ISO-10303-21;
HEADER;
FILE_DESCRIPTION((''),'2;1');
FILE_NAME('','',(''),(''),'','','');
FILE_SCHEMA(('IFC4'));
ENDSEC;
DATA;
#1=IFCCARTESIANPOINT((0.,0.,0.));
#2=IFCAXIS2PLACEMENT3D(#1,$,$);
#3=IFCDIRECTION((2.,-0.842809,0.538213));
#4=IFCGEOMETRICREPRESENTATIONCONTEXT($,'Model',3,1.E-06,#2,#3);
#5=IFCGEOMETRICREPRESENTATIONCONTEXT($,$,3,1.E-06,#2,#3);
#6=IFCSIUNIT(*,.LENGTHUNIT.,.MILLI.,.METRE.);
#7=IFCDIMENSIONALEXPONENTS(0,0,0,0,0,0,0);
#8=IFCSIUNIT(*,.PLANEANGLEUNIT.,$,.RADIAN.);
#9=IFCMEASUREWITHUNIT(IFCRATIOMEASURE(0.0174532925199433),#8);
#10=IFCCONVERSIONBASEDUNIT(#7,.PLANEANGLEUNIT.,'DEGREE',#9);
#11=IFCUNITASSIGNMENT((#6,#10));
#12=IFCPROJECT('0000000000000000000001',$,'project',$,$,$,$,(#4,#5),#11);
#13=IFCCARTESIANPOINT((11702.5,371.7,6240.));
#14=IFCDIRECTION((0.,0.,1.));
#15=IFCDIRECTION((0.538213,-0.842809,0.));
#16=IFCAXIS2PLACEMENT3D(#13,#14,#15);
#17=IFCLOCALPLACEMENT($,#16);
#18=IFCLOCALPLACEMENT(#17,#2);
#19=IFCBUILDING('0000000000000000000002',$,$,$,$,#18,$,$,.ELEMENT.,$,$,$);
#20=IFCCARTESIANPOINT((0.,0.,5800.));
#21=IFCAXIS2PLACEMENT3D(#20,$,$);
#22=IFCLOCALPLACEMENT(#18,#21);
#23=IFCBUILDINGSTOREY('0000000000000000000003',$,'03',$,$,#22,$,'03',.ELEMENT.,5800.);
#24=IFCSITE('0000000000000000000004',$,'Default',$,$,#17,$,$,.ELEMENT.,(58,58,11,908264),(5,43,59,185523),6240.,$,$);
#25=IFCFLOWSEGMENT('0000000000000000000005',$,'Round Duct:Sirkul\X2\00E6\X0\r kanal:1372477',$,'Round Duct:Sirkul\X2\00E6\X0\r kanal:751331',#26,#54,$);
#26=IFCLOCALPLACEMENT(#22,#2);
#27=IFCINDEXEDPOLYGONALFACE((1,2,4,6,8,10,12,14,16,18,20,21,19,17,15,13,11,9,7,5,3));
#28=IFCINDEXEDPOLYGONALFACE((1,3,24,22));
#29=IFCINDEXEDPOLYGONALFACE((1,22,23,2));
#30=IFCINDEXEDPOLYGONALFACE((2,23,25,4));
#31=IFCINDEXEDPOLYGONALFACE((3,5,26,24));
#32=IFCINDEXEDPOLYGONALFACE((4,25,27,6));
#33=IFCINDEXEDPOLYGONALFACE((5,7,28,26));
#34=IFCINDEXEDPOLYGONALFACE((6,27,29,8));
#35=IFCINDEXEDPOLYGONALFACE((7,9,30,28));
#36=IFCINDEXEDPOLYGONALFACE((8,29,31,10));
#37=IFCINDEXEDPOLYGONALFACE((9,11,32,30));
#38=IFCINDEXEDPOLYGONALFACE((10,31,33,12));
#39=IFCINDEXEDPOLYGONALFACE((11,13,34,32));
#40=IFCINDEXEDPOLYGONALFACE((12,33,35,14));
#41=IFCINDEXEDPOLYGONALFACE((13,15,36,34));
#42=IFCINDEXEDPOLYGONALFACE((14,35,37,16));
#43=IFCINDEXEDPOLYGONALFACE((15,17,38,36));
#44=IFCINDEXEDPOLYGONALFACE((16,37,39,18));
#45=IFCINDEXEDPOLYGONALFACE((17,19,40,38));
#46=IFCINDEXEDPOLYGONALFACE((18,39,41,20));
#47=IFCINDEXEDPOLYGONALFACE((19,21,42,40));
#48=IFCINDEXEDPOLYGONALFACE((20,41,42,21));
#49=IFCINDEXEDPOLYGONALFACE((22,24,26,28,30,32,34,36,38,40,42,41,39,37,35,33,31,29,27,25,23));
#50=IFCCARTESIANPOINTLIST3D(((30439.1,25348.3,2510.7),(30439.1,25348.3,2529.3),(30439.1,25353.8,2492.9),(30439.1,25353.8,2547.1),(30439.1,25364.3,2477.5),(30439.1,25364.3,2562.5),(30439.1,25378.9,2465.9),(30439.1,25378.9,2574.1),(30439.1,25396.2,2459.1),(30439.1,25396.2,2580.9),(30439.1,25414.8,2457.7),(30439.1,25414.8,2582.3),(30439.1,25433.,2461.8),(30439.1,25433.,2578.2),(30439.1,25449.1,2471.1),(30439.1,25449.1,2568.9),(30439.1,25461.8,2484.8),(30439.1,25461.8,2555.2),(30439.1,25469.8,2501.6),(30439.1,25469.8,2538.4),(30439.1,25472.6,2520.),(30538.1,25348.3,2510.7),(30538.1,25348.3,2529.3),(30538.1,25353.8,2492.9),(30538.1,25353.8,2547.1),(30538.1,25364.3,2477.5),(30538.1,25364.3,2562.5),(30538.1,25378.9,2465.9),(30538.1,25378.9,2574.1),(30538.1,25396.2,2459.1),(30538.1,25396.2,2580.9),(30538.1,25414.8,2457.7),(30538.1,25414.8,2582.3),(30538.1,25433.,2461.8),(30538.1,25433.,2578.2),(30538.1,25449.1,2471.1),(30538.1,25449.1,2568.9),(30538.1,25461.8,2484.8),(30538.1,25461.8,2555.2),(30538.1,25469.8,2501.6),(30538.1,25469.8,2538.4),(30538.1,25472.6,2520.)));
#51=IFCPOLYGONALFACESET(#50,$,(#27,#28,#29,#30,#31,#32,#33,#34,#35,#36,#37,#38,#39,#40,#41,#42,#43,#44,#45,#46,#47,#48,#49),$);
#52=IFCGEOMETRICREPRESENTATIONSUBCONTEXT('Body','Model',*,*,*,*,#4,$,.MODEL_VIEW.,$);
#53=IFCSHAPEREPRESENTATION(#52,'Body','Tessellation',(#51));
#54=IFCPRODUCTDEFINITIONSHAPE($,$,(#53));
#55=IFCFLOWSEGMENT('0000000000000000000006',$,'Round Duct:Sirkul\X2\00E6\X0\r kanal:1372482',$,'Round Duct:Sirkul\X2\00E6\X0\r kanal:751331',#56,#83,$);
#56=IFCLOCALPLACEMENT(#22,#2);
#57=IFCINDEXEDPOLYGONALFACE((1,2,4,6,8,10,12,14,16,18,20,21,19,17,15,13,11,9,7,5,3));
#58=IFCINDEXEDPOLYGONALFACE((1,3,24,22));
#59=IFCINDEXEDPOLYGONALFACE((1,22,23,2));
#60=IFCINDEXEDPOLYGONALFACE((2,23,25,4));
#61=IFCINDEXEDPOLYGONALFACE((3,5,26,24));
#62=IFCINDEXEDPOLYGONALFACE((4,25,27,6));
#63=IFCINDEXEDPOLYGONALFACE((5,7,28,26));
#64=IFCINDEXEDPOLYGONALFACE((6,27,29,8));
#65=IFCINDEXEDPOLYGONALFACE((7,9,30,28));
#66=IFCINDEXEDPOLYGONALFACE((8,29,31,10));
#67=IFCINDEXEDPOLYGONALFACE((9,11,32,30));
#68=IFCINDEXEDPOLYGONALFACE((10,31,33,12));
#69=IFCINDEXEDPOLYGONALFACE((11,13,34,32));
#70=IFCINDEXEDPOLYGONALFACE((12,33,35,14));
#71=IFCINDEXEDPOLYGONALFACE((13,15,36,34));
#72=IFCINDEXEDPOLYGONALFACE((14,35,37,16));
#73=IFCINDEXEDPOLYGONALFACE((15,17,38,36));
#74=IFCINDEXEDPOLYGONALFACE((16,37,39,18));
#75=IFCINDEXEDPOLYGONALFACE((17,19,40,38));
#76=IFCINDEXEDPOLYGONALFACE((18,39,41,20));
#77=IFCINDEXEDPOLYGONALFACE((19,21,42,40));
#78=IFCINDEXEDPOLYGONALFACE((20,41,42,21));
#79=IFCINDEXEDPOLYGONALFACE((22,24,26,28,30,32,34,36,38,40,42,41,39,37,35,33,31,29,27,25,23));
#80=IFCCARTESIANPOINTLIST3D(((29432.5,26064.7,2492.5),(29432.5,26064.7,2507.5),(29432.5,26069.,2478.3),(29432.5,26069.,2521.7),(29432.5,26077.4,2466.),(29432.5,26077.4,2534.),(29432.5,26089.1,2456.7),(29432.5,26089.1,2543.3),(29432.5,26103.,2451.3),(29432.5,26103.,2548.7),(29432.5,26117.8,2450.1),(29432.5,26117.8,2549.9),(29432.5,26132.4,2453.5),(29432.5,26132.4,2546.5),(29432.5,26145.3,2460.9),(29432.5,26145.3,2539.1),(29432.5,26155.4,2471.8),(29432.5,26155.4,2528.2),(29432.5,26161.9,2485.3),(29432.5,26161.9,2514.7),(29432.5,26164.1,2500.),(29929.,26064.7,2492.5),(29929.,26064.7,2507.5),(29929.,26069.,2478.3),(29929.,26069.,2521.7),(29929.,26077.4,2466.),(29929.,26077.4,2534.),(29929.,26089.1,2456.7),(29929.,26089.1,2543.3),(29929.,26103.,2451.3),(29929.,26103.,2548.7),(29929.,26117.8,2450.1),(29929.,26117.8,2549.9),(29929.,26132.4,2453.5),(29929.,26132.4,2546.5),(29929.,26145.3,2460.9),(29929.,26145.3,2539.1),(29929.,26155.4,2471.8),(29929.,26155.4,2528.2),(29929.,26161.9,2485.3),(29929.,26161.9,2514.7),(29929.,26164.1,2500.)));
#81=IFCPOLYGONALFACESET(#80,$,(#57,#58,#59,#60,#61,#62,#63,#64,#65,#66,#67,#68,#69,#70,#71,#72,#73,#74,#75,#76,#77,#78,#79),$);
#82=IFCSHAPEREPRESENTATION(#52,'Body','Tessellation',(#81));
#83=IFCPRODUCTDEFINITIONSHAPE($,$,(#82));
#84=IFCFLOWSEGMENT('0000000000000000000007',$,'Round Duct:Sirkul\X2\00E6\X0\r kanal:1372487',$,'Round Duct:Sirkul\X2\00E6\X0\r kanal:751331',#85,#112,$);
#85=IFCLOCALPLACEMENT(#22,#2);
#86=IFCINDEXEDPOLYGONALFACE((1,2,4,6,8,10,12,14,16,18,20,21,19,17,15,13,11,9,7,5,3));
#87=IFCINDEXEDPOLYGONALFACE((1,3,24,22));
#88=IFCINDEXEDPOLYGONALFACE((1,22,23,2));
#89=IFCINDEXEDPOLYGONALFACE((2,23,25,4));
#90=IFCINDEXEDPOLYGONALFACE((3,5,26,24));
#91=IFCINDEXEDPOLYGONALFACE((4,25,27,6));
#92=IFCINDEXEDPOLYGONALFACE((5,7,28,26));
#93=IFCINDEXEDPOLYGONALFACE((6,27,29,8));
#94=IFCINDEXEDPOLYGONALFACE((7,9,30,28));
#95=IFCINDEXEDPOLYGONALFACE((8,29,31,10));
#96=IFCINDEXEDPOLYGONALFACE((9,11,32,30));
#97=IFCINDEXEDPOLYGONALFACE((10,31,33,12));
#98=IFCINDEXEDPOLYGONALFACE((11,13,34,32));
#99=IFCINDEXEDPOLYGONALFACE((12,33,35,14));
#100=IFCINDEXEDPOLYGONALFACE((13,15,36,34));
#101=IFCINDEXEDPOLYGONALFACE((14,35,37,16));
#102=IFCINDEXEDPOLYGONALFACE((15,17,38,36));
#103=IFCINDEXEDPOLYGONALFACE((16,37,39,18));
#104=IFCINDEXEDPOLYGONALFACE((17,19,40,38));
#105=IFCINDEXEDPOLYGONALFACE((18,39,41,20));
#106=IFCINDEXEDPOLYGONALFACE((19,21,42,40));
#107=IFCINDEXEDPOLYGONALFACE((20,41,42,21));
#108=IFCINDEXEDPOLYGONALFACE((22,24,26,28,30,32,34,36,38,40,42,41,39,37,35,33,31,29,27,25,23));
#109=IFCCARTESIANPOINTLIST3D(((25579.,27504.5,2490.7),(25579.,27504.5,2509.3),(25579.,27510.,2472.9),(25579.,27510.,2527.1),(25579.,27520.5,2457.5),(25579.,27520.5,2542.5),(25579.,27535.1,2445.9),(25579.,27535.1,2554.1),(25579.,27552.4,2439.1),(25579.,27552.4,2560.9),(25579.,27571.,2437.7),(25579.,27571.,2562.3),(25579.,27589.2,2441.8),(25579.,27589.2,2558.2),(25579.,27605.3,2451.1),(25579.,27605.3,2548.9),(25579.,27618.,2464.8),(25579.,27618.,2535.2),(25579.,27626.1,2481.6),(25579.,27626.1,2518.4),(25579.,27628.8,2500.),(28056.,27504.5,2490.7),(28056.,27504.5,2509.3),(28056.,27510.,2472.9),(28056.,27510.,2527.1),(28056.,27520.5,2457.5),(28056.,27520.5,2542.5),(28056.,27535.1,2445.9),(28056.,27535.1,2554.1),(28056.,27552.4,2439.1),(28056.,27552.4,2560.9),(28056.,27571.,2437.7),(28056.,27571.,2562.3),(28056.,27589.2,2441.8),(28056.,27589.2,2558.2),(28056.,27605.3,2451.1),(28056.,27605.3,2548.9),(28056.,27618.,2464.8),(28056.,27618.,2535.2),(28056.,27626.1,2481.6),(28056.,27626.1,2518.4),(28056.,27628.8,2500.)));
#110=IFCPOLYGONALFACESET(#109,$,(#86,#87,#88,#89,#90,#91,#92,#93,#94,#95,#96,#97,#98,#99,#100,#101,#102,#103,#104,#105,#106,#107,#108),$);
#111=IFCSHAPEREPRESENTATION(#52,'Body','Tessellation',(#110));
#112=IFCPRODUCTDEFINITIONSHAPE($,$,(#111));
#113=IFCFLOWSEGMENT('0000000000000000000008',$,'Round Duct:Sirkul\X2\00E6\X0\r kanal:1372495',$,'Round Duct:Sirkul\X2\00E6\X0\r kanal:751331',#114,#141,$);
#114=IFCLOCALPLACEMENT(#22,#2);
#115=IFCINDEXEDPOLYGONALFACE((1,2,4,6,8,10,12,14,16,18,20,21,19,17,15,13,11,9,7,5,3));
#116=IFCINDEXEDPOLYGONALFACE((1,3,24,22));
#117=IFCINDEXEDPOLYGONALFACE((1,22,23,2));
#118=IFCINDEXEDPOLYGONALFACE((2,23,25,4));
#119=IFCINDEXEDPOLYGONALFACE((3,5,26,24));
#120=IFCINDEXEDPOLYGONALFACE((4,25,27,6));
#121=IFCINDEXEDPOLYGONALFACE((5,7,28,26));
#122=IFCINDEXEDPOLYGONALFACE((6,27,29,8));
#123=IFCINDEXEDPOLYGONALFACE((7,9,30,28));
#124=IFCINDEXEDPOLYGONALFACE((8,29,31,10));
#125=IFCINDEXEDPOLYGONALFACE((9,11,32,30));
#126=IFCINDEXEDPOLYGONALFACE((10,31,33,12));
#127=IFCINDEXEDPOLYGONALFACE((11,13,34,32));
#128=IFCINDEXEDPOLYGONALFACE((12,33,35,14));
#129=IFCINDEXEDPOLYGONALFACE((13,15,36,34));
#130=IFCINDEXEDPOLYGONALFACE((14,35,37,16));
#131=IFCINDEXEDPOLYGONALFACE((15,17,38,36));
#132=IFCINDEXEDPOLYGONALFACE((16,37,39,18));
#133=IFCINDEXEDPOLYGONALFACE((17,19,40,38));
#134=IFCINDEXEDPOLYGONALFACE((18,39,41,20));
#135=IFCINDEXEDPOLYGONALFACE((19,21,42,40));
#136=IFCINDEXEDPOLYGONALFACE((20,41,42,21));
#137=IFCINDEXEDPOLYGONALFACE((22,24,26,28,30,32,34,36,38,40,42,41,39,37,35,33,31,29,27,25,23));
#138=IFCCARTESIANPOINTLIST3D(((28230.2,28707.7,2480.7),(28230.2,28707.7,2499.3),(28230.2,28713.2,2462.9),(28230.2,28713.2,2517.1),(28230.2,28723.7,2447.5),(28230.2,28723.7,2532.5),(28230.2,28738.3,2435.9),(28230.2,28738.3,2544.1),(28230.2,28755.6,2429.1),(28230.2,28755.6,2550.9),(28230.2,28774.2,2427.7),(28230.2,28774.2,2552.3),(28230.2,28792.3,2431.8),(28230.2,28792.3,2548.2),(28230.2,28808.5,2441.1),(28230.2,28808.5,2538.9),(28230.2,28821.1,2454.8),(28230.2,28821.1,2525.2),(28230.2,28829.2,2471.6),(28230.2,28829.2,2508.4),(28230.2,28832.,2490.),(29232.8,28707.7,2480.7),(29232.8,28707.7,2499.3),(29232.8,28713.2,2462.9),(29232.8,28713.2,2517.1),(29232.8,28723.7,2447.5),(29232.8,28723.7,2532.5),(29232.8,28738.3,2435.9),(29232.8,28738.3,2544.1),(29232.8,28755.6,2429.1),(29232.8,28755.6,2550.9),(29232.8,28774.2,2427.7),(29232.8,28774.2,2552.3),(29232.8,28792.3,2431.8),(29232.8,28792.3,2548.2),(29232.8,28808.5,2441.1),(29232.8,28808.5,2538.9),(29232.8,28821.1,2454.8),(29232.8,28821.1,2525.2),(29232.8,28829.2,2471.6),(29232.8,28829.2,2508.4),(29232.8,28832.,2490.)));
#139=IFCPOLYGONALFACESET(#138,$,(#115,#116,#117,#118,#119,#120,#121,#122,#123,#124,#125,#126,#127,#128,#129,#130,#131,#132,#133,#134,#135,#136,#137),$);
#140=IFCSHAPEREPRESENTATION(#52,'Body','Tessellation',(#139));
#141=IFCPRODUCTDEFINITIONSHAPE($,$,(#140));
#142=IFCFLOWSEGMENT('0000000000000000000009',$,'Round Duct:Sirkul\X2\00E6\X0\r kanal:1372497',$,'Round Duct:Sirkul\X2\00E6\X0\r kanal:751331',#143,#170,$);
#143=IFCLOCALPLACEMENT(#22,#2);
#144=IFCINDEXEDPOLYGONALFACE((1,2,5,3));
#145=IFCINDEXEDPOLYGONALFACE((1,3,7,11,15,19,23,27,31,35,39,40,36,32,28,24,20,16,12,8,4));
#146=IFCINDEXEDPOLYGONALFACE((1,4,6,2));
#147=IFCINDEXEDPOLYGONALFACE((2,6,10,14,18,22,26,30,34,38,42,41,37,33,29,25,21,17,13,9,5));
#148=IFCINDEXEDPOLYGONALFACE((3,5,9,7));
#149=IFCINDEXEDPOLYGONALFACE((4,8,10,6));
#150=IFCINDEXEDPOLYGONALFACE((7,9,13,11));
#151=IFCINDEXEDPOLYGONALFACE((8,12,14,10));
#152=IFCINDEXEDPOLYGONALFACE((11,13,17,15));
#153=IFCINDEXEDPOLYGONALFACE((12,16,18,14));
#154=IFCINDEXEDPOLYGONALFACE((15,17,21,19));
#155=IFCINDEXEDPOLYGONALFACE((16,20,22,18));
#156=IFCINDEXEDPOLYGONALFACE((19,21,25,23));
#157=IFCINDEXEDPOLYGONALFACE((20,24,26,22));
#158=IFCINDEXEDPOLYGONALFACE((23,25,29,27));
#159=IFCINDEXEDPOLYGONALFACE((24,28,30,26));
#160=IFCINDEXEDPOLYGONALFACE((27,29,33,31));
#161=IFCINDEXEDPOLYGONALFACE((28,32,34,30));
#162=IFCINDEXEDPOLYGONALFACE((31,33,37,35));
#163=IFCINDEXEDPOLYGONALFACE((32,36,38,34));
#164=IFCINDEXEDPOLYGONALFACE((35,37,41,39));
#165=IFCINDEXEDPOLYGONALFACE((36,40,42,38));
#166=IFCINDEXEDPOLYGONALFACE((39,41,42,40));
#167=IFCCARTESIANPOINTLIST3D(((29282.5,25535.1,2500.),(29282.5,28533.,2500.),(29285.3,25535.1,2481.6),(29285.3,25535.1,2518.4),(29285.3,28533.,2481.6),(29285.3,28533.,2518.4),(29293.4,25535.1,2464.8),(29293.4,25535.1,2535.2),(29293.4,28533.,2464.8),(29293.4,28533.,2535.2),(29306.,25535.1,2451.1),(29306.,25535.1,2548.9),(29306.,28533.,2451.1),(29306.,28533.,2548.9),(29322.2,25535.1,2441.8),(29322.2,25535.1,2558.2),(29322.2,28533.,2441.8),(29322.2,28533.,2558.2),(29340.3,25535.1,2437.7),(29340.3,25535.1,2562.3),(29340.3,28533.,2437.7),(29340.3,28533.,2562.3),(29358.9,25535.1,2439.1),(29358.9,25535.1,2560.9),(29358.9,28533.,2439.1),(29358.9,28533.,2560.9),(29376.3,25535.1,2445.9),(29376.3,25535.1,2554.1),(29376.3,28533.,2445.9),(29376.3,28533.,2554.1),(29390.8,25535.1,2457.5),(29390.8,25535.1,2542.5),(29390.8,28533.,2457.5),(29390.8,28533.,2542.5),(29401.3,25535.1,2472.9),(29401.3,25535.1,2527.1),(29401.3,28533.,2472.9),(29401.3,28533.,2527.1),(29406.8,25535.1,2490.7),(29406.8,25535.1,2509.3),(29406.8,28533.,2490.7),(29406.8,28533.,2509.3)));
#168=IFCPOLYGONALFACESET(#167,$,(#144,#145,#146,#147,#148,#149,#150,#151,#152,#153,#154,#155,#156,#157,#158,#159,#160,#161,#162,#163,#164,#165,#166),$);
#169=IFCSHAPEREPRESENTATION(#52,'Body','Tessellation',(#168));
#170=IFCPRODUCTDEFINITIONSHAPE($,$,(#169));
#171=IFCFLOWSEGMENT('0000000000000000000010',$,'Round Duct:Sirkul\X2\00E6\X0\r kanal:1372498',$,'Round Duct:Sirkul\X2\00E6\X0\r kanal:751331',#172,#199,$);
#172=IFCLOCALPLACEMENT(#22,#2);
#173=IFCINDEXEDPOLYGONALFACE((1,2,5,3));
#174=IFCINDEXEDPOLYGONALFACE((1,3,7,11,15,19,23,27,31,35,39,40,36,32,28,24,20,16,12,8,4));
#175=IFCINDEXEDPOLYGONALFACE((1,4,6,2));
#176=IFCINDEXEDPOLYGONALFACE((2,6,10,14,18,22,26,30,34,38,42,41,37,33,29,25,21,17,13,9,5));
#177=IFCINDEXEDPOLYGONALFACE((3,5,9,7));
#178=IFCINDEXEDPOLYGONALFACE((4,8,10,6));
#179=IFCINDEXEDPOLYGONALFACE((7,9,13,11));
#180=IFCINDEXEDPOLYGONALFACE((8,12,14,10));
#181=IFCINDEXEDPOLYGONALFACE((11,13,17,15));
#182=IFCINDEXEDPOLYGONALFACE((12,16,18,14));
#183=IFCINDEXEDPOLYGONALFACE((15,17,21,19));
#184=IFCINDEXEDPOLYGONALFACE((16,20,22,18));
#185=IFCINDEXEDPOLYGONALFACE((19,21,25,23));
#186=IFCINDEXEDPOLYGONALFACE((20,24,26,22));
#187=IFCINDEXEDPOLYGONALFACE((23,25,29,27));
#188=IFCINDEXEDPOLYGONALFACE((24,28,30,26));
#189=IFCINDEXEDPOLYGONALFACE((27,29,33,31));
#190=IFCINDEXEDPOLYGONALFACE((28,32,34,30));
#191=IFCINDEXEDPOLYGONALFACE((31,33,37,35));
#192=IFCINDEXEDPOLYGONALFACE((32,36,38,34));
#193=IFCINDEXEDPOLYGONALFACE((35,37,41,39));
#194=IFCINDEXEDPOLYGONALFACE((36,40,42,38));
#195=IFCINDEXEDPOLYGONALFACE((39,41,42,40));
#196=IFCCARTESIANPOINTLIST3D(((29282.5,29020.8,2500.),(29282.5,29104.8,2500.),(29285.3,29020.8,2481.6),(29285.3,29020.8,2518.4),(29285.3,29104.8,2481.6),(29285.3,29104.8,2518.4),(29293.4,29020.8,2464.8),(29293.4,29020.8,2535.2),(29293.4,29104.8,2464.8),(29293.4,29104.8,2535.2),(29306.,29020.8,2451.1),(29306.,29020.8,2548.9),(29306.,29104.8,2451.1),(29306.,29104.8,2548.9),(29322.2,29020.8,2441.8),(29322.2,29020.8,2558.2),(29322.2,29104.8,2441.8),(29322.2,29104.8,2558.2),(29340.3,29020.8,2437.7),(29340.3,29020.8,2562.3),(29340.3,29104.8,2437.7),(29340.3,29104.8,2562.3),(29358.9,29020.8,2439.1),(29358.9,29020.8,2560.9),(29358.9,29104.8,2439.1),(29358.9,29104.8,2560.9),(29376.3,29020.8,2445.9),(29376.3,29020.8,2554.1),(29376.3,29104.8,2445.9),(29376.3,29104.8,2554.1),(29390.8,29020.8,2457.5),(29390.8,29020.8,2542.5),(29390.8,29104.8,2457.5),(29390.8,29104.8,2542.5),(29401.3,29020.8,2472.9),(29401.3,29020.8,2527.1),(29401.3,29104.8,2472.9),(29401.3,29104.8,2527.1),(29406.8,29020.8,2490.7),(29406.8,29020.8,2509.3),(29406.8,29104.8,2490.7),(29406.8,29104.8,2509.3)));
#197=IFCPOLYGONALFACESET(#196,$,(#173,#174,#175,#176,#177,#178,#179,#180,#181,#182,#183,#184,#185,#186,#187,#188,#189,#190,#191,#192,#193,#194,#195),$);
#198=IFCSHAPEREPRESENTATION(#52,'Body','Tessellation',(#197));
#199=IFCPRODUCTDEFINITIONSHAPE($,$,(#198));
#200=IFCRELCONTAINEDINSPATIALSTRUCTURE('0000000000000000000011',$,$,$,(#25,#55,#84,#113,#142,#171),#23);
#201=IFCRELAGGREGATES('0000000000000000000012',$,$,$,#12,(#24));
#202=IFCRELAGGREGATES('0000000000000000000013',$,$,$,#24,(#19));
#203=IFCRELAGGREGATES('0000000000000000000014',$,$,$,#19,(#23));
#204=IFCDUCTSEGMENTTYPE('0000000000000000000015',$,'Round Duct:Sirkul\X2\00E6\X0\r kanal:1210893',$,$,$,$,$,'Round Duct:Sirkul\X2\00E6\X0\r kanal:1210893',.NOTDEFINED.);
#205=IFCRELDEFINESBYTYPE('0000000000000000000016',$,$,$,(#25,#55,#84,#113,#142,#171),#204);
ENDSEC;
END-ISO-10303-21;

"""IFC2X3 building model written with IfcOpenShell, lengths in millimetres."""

from ifc_helpers import new_model, entity, si_unit, converted_unit, direction, frame, frame_2d, origin, origin_2d_with_axis, place, context, subcontext, project, spatial, circle, extrude, type_object, element, save


model = new_model("IFC2X3")

# Units and contexts
model_context = context("Model", 3, precision=1e-06, world=origin(), true_north=direction((2.0, -0.842809, 0.538213)))
context_of_model = context(None, 3, precision=1e-06, world=origin(), true_north=direction((2.0, -0.842809, 0.538213)))
body_context = subcontext(model_context, "Body", "Model", "MODEL_VIEW")
ifc_project = project(units=[si_unit("LENGTHUNIT", "METRE", prefix="MILLI"), converted_unit("PLANEANGLEUNIT", "DEGREE", entity("IfcRatioMeasure", 0.0174532925199433), si_unit("PLANEANGLEUNIT", "RADIAN"), dimensions=[0, 0, 0, 0, 0, 0, 0])], contexts=[model_context, context_of_model])

# Site, building, storey
site_placement = place(None, frame((11702.5, 371.7, 6240.0), z_axis=(0.0, 0.0, 1.0), x_axis=(0.538213, -0.842809, 0.0)))
site = spatial("IfcSite", under=ifc_project, at=site_placement, Name="Default", CompositionType="ELEMENT", RefLatitude=(58, 58, 11, 908264), RefLongitude=(5, 43, 59, 185523), RefElevation=6240.0)
building_placement = place(site_placement, origin())
building = spatial("IfcBuilding", under=site, at=building_placement, CompositionType="ELEMENT")
storey_placement = place(building_placement, frame((0.0, 0.0, 5800.0)))
storey = spatial("IfcBuildingStorey", under=building, at=storey_placement, Name="03", LongName="03", CompositionType="ELEMENT", Elevation=5800.0)

# Flow segments
duct_segment_type_1 = type_object("IfcDuctSegmentType", Name="Round Duct:Sirkulær kanal:1210893", ElementType="Round Duct:Sirkulær kanal:1210893", PredefinedType="NOTDEFINED")
flow_segment_1_placement = place(storey_placement, origin())
element("IfcFlowSegment", 1, at=flow_segment_1_placement, inside=storey, type_object=duct_segment_type_1, Name="Round Duct:Sirkulær kanal:1372477", ObjectType="Round Duct:Sirkulær kanal:751331", context=body_context, shape_type="SweptSolid", body=[
    extrude(circle(Radius=62.5, at=origin_2d_with_axis()), frame((30439.1, 25410.1, 2520.0), z_axis=(1.0, 0.0, 0.0), x_axis=(0.0, 1.0, 0.0)), (0.0, 0.0, 1.0), 99.1),
])
flow_segment_2_placement = place(storey_placement, origin())
element("IfcFlowSegment", 2, at=flow_segment_2_placement, inside=storey, type_object=duct_segment_type_1, Name="Round Duct:Sirkulær kanal:1372482", ObjectType="Round Duct:Sirkulær kanal:751331", context=body_context, shape_type="SweptSolid", body=[
    extrude(circle(Radius=50.0, at=origin_2d_with_axis()), frame((29432.5, 26114.1, 2500.0), z_axis=(1.0, 0.0, 0.0), x_axis=(0.0, 1.0, 0.0)), (0.0, 0.0, 1.0), 496.5),
])
flow_segment_3_placement = place(storey_placement, origin())
element("IfcFlowSegment", 3, at=flow_segment_3_placement, inside=storey, type_object=duct_segment_type_1, Name="Round Duct:Sirkulær kanal:1372487", ObjectType="Round Duct:Sirkulær kanal:751331", context=body_context, shape_type="SweptSolid", body=[
    extrude(circle(Radius=62.5, at=frame_2d((0.0, 0.0), x_axis=(1.0, 0.0))), frame((25579.0, 27566.3, 2500.0), z_axis=(1.0, 0.0, 0.0), x_axis=(0.0, 1.0, 0.0)), (0.0, 0.0, 1.0), 2477.0),
])
flow_segment_4_placement = place(storey_placement, origin())
element("IfcFlowSegment", 4, at=flow_segment_4_placement, inside=storey, type_object=duct_segment_type_1, Name="Round Duct:Sirkulær kanal:1372495", ObjectType="Round Duct:Sirkulær kanal:751331", context=body_context, shape_type="SweptSolid", body=[
    extrude(circle(Radius=62.5, at=origin_2d_with_axis()), frame((28230.2, 28769.5, 2490.0), z_axis=(1.0, 0.000003, 0.0), x_axis=(-0.000003, 1.0, 0.0)), (0.0, 0.0, 1.0), 1002.6),
])
flow_segment_5_placement = place(storey_placement, origin())
element("IfcFlowSegment", 5, at=flow_segment_5_placement, inside=storey, type_object=duct_segment_type_1, Name="Round Duct:Sirkulær kanal:1372497", ObjectType="Round Duct:Sirkulær kanal:751331", context=body_context, shape_type="SweptSolid", body=[
    extrude(circle(Radius=62.5, at=origin_2d_with_axis()), frame((29345.0, 25535.1, 2500.0), z_axis=(0.0, 1.0, 0.0), x_axis=(-1.0, 0.0, 0.0)), (0.0, 0.0, 1.0), 2997.9),
])
flow_segment_6_placement = place(storey_placement, origin())
element("IfcFlowSegment", 6, at=flow_segment_6_placement, inside=storey, type_object=duct_segment_type_1, Name="Round Duct:Sirkulær kanal:1372498", ObjectType="Round Duct:Sirkulær kanal:751331", context=body_context, shape_type="SweptSolid", body=[
    extrude(circle(Radius=62.5, at=frame_2d((0.0, 0.0), x_axis=(1.0, 0.0))), frame((29345.0, 29020.8, 2500.0), z_axis=(0.0, 1.0, 0.0), x_axis=(-1.0, 0.0, 0.0)), (0.0, 0.0, 1.0), 84.0),
])

save(model, "model.ifc")
